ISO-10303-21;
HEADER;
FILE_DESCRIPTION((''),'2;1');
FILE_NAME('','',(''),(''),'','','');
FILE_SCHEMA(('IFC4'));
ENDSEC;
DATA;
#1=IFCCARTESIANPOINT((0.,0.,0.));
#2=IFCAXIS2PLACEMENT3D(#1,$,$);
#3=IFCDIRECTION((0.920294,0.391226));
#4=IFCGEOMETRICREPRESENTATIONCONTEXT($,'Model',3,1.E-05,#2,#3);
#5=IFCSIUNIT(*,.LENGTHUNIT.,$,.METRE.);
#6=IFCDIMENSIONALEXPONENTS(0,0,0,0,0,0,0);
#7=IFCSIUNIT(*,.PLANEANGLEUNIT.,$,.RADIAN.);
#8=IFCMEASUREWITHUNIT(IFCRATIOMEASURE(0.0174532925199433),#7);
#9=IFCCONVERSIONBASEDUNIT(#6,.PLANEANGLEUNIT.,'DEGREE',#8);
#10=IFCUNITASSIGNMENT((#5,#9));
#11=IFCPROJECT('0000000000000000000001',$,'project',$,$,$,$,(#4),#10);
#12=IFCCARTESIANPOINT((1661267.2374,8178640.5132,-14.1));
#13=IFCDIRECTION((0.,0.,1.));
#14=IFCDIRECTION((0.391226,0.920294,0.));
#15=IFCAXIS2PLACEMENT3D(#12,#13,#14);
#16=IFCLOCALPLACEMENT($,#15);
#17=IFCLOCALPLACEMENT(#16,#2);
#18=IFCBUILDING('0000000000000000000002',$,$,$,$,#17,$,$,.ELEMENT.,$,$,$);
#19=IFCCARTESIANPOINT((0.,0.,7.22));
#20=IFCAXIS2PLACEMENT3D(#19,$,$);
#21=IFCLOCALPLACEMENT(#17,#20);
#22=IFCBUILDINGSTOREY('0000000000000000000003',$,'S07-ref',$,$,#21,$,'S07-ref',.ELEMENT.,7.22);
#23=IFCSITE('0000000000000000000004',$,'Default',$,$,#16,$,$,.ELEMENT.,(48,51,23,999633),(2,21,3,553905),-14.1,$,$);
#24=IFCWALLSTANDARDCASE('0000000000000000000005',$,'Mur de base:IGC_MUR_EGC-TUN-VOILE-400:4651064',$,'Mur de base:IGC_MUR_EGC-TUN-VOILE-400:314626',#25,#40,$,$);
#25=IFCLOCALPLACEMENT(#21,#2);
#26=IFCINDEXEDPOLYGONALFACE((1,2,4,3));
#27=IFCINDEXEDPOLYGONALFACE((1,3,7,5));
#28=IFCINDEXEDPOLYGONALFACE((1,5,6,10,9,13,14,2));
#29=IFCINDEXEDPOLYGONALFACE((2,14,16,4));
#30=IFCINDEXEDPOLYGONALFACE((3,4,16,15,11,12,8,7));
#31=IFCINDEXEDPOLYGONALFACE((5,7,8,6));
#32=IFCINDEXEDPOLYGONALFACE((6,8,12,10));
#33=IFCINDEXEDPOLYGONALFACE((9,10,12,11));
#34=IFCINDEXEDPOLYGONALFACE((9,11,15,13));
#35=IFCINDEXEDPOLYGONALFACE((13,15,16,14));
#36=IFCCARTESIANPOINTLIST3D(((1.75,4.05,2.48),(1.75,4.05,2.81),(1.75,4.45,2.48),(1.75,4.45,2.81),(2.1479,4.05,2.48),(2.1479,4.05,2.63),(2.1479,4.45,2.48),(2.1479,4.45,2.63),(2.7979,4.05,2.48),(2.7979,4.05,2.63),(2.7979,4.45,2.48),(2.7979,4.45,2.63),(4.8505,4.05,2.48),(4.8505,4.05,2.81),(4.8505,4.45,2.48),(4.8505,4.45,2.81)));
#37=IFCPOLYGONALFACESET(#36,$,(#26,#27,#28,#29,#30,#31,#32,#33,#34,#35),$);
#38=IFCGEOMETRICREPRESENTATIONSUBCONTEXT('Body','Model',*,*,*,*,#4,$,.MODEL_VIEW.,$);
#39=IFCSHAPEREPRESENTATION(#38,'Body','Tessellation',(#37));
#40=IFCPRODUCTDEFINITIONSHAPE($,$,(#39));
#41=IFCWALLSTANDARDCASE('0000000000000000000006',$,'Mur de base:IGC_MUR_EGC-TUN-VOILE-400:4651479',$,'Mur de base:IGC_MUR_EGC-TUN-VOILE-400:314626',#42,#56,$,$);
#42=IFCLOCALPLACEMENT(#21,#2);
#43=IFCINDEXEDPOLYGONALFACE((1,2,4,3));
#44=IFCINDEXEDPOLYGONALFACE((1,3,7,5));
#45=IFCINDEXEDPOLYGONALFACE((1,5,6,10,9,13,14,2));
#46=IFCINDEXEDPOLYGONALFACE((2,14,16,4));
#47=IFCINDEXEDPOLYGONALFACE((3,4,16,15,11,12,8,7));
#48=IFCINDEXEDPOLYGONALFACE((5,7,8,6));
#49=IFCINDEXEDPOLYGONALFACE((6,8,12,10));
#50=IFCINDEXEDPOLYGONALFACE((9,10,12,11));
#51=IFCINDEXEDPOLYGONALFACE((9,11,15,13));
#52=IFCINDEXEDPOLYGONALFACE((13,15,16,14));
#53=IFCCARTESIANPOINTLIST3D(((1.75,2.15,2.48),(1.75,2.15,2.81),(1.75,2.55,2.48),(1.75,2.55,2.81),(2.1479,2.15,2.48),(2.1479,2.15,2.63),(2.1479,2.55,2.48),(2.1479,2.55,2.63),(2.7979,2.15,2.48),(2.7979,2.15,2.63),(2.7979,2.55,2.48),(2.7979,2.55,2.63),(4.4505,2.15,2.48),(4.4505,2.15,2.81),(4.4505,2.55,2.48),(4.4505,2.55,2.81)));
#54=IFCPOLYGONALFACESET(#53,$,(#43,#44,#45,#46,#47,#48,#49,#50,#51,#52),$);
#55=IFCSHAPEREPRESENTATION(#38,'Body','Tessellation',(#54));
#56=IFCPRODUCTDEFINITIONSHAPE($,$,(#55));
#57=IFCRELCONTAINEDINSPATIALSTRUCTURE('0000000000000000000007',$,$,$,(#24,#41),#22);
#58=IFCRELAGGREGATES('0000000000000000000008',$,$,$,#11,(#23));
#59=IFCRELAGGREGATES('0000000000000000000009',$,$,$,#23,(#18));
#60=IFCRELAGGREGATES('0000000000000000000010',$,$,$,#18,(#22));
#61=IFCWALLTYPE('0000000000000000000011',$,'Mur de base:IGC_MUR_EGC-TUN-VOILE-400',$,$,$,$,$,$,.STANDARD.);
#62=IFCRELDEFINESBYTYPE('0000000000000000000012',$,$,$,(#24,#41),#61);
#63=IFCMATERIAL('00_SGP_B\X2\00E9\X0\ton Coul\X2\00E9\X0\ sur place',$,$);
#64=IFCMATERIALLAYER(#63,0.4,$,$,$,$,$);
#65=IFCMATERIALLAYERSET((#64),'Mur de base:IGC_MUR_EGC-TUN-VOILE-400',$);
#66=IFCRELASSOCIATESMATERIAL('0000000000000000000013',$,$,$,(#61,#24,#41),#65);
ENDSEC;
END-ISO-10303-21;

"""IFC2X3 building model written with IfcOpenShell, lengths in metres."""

from ifc_helpers import new_model, entity, si_unit, converted_unit, direction, frame, frame_2d, origin, place, context, subcontext, project, spatial, rectangle, extrude, material, layer, layer_set, layer_usage, type_object, element, save


model = new_model("IFC2X3")

# Units and contexts
model_context = context("Model", 3, precision=1e-05, world=origin(), true_north=direction((0.920294, 0.391226)))
body_context = subcontext(model_context, "Body", "Model", "MODEL_VIEW")
ifc_project = project(units=[si_unit("LENGTHUNIT", "METRE"), converted_unit("PLANEANGLEUNIT", "DEGREE", entity("IfcRatioMeasure", 0.0174532925199433), si_unit("PLANEANGLEUNIT", "RADIAN"), dimensions=[0, 0, 0, 0, 0, 0, 0])], contexts=[model_context])

# Site, building, storey
site_placement = place(None, frame((1661267.2374, 8178640.5132, -14.1), z_axis=(0.0, 0.0, 1.0), x_axis=(0.391226, 0.920294, 0.0)))
site = spatial("IfcSite", under=ifc_project, at=site_placement, Name="Default", CompositionType="ELEMENT", RefLatitude=(48, 51, 23, 999633), RefLongitude=(2, 21, 3, 553905), RefElevation=-14.1)
building_placement = place(site_placement, origin())
building = spatial("IfcBuilding", under=site, at=building_placement, CompositionType="ELEMENT")
storey_placement = place(building_placement, frame((0.0, 0.0, 7.22)))
storey = spatial("IfcBuildingStorey", under=building, at=storey_placement, Name="S07-ref", LongName="S07-ref", CompositionType="ELEMENT", Elevation=7.22)

# Shared definitions
ifc_material_1 = material(Name="00_SGP_Béton Coulé sur place")

# Shared definitions
ifc_layer_1 = layer(ifc_material_1, 0.4)
ifc_layer_set_1 = layer_set([ifc_layer_1], Name="Mur de base:IGC_MUR_EGC-TUN-VOILE-400")
wall_type_1 = type_object("IfcWallType", Name="Mur de base:IGC_MUR_EGC-TUN-VOILE-400", PredefinedType="STANDARD", material=ifc_layer_set_1)

# Walls, openings
ifc_layer_usage_1 = layer_usage(ifc_layer_set_1, "AXIS2", "NEGATIVE", 0.2)
wall_1_placement = place(storey_placement, frame((4.8505, 4.25, 2.48), z_axis=(0.0, 0.0, 1.0), x_axis=(-1.0, 0.0, 0.0)))
wall_1 = element("IfcWallStandardCase", 1, at=wall_1_placement, inside=storey, type_object=wall_type_1, material=ifc_layer_usage_1, Name="Mur de base:IGC_MUR_EGC-TUN-VOILE-400:4651064", ObjectType="Mur de base:IGC_MUR_EGC-TUN-VOILE-400:314626", context=body_context, shape_type="SweptSolid", body=[
    extrude(rectangle(XDim=3.1005, YDim=0.4, at=frame_2d((1.5502, 0.0), x_axis=(-1.0, 0.0))), origin(), (0.0, 0.0, 1.0), 0.33),
])
opening_1_placement = place(wall_1_placement, origin())
element("IfcOpeningElement", 2, at=opening_1_placement, cuts=wall_1, ObjectType="Opening", context=body_context, shape_type="SweptSolid", body=[
    extrude(rectangle(XDim=0.15, YDim=0.65, at=frame_2d((0.0, 0.0), x_axis=(0.0, 1.0))), frame((2.3775, -1.724, 0.075), z_axis=(0.0, 1.0, 0.0), x_axis=(1.0, 0.0, 0.0)), (0.0, 0.0, 1.0), 3.048),
])
ifc_layer_usage_2 = layer_usage(ifc_layer_set_1, "AXIS2", "NEGATIVE", 0.2)
wall_2_placement = place(storey_placement, frame((4.4505, 2.35, 2.48), z_axis=(0.0, 0.0, 1.0), x_axis=(-1.0, 0.0, 0.0)))
wall_2 = element("IfcWallStandardCase", 3, at=wall_2_placement, inside=storey, type_object=wall_type_1, material=ifc_layer_usage_2, Name="Mur de base:IGC_MUR_EGC-TUN-VOILE-400:4651479", ObjectType="Mur de base:IGC_MUR_EGC-TUN-VOILE-400:314626", context=body_context, shape_type="SweptSolid", body=[
    extrude(rectangle(XDim=2.7005, YDim=0.4, at=frame_2d((1.3502, 0.0), x_axis=(-1.0, 0.0))), origin(), (0.0, 0.0, 1.0), 0.33),
])
opening_2_placement = place(wall_2_placement, origin())
element("IfcOpeningElement", 4, at=opening_2_placement, cuts=wall_2, ObjectType="Opening", context=body_context, shape_type="SweptSolid", body=[
    extrude(rectangle(XDim=0.15, YDim=0.65, at=frame_2d((0.0, 0.0), x_axis=(1.0, 0.0))), frame((1.9775, -1.324, 0.075), z_axis=(0.0, 1.0, 0.0), x_axis=(0.0, 0.0, -1.0)), (0.0, 0.0, 1.0), 3.048),
])

save(model, "model.ifc")
